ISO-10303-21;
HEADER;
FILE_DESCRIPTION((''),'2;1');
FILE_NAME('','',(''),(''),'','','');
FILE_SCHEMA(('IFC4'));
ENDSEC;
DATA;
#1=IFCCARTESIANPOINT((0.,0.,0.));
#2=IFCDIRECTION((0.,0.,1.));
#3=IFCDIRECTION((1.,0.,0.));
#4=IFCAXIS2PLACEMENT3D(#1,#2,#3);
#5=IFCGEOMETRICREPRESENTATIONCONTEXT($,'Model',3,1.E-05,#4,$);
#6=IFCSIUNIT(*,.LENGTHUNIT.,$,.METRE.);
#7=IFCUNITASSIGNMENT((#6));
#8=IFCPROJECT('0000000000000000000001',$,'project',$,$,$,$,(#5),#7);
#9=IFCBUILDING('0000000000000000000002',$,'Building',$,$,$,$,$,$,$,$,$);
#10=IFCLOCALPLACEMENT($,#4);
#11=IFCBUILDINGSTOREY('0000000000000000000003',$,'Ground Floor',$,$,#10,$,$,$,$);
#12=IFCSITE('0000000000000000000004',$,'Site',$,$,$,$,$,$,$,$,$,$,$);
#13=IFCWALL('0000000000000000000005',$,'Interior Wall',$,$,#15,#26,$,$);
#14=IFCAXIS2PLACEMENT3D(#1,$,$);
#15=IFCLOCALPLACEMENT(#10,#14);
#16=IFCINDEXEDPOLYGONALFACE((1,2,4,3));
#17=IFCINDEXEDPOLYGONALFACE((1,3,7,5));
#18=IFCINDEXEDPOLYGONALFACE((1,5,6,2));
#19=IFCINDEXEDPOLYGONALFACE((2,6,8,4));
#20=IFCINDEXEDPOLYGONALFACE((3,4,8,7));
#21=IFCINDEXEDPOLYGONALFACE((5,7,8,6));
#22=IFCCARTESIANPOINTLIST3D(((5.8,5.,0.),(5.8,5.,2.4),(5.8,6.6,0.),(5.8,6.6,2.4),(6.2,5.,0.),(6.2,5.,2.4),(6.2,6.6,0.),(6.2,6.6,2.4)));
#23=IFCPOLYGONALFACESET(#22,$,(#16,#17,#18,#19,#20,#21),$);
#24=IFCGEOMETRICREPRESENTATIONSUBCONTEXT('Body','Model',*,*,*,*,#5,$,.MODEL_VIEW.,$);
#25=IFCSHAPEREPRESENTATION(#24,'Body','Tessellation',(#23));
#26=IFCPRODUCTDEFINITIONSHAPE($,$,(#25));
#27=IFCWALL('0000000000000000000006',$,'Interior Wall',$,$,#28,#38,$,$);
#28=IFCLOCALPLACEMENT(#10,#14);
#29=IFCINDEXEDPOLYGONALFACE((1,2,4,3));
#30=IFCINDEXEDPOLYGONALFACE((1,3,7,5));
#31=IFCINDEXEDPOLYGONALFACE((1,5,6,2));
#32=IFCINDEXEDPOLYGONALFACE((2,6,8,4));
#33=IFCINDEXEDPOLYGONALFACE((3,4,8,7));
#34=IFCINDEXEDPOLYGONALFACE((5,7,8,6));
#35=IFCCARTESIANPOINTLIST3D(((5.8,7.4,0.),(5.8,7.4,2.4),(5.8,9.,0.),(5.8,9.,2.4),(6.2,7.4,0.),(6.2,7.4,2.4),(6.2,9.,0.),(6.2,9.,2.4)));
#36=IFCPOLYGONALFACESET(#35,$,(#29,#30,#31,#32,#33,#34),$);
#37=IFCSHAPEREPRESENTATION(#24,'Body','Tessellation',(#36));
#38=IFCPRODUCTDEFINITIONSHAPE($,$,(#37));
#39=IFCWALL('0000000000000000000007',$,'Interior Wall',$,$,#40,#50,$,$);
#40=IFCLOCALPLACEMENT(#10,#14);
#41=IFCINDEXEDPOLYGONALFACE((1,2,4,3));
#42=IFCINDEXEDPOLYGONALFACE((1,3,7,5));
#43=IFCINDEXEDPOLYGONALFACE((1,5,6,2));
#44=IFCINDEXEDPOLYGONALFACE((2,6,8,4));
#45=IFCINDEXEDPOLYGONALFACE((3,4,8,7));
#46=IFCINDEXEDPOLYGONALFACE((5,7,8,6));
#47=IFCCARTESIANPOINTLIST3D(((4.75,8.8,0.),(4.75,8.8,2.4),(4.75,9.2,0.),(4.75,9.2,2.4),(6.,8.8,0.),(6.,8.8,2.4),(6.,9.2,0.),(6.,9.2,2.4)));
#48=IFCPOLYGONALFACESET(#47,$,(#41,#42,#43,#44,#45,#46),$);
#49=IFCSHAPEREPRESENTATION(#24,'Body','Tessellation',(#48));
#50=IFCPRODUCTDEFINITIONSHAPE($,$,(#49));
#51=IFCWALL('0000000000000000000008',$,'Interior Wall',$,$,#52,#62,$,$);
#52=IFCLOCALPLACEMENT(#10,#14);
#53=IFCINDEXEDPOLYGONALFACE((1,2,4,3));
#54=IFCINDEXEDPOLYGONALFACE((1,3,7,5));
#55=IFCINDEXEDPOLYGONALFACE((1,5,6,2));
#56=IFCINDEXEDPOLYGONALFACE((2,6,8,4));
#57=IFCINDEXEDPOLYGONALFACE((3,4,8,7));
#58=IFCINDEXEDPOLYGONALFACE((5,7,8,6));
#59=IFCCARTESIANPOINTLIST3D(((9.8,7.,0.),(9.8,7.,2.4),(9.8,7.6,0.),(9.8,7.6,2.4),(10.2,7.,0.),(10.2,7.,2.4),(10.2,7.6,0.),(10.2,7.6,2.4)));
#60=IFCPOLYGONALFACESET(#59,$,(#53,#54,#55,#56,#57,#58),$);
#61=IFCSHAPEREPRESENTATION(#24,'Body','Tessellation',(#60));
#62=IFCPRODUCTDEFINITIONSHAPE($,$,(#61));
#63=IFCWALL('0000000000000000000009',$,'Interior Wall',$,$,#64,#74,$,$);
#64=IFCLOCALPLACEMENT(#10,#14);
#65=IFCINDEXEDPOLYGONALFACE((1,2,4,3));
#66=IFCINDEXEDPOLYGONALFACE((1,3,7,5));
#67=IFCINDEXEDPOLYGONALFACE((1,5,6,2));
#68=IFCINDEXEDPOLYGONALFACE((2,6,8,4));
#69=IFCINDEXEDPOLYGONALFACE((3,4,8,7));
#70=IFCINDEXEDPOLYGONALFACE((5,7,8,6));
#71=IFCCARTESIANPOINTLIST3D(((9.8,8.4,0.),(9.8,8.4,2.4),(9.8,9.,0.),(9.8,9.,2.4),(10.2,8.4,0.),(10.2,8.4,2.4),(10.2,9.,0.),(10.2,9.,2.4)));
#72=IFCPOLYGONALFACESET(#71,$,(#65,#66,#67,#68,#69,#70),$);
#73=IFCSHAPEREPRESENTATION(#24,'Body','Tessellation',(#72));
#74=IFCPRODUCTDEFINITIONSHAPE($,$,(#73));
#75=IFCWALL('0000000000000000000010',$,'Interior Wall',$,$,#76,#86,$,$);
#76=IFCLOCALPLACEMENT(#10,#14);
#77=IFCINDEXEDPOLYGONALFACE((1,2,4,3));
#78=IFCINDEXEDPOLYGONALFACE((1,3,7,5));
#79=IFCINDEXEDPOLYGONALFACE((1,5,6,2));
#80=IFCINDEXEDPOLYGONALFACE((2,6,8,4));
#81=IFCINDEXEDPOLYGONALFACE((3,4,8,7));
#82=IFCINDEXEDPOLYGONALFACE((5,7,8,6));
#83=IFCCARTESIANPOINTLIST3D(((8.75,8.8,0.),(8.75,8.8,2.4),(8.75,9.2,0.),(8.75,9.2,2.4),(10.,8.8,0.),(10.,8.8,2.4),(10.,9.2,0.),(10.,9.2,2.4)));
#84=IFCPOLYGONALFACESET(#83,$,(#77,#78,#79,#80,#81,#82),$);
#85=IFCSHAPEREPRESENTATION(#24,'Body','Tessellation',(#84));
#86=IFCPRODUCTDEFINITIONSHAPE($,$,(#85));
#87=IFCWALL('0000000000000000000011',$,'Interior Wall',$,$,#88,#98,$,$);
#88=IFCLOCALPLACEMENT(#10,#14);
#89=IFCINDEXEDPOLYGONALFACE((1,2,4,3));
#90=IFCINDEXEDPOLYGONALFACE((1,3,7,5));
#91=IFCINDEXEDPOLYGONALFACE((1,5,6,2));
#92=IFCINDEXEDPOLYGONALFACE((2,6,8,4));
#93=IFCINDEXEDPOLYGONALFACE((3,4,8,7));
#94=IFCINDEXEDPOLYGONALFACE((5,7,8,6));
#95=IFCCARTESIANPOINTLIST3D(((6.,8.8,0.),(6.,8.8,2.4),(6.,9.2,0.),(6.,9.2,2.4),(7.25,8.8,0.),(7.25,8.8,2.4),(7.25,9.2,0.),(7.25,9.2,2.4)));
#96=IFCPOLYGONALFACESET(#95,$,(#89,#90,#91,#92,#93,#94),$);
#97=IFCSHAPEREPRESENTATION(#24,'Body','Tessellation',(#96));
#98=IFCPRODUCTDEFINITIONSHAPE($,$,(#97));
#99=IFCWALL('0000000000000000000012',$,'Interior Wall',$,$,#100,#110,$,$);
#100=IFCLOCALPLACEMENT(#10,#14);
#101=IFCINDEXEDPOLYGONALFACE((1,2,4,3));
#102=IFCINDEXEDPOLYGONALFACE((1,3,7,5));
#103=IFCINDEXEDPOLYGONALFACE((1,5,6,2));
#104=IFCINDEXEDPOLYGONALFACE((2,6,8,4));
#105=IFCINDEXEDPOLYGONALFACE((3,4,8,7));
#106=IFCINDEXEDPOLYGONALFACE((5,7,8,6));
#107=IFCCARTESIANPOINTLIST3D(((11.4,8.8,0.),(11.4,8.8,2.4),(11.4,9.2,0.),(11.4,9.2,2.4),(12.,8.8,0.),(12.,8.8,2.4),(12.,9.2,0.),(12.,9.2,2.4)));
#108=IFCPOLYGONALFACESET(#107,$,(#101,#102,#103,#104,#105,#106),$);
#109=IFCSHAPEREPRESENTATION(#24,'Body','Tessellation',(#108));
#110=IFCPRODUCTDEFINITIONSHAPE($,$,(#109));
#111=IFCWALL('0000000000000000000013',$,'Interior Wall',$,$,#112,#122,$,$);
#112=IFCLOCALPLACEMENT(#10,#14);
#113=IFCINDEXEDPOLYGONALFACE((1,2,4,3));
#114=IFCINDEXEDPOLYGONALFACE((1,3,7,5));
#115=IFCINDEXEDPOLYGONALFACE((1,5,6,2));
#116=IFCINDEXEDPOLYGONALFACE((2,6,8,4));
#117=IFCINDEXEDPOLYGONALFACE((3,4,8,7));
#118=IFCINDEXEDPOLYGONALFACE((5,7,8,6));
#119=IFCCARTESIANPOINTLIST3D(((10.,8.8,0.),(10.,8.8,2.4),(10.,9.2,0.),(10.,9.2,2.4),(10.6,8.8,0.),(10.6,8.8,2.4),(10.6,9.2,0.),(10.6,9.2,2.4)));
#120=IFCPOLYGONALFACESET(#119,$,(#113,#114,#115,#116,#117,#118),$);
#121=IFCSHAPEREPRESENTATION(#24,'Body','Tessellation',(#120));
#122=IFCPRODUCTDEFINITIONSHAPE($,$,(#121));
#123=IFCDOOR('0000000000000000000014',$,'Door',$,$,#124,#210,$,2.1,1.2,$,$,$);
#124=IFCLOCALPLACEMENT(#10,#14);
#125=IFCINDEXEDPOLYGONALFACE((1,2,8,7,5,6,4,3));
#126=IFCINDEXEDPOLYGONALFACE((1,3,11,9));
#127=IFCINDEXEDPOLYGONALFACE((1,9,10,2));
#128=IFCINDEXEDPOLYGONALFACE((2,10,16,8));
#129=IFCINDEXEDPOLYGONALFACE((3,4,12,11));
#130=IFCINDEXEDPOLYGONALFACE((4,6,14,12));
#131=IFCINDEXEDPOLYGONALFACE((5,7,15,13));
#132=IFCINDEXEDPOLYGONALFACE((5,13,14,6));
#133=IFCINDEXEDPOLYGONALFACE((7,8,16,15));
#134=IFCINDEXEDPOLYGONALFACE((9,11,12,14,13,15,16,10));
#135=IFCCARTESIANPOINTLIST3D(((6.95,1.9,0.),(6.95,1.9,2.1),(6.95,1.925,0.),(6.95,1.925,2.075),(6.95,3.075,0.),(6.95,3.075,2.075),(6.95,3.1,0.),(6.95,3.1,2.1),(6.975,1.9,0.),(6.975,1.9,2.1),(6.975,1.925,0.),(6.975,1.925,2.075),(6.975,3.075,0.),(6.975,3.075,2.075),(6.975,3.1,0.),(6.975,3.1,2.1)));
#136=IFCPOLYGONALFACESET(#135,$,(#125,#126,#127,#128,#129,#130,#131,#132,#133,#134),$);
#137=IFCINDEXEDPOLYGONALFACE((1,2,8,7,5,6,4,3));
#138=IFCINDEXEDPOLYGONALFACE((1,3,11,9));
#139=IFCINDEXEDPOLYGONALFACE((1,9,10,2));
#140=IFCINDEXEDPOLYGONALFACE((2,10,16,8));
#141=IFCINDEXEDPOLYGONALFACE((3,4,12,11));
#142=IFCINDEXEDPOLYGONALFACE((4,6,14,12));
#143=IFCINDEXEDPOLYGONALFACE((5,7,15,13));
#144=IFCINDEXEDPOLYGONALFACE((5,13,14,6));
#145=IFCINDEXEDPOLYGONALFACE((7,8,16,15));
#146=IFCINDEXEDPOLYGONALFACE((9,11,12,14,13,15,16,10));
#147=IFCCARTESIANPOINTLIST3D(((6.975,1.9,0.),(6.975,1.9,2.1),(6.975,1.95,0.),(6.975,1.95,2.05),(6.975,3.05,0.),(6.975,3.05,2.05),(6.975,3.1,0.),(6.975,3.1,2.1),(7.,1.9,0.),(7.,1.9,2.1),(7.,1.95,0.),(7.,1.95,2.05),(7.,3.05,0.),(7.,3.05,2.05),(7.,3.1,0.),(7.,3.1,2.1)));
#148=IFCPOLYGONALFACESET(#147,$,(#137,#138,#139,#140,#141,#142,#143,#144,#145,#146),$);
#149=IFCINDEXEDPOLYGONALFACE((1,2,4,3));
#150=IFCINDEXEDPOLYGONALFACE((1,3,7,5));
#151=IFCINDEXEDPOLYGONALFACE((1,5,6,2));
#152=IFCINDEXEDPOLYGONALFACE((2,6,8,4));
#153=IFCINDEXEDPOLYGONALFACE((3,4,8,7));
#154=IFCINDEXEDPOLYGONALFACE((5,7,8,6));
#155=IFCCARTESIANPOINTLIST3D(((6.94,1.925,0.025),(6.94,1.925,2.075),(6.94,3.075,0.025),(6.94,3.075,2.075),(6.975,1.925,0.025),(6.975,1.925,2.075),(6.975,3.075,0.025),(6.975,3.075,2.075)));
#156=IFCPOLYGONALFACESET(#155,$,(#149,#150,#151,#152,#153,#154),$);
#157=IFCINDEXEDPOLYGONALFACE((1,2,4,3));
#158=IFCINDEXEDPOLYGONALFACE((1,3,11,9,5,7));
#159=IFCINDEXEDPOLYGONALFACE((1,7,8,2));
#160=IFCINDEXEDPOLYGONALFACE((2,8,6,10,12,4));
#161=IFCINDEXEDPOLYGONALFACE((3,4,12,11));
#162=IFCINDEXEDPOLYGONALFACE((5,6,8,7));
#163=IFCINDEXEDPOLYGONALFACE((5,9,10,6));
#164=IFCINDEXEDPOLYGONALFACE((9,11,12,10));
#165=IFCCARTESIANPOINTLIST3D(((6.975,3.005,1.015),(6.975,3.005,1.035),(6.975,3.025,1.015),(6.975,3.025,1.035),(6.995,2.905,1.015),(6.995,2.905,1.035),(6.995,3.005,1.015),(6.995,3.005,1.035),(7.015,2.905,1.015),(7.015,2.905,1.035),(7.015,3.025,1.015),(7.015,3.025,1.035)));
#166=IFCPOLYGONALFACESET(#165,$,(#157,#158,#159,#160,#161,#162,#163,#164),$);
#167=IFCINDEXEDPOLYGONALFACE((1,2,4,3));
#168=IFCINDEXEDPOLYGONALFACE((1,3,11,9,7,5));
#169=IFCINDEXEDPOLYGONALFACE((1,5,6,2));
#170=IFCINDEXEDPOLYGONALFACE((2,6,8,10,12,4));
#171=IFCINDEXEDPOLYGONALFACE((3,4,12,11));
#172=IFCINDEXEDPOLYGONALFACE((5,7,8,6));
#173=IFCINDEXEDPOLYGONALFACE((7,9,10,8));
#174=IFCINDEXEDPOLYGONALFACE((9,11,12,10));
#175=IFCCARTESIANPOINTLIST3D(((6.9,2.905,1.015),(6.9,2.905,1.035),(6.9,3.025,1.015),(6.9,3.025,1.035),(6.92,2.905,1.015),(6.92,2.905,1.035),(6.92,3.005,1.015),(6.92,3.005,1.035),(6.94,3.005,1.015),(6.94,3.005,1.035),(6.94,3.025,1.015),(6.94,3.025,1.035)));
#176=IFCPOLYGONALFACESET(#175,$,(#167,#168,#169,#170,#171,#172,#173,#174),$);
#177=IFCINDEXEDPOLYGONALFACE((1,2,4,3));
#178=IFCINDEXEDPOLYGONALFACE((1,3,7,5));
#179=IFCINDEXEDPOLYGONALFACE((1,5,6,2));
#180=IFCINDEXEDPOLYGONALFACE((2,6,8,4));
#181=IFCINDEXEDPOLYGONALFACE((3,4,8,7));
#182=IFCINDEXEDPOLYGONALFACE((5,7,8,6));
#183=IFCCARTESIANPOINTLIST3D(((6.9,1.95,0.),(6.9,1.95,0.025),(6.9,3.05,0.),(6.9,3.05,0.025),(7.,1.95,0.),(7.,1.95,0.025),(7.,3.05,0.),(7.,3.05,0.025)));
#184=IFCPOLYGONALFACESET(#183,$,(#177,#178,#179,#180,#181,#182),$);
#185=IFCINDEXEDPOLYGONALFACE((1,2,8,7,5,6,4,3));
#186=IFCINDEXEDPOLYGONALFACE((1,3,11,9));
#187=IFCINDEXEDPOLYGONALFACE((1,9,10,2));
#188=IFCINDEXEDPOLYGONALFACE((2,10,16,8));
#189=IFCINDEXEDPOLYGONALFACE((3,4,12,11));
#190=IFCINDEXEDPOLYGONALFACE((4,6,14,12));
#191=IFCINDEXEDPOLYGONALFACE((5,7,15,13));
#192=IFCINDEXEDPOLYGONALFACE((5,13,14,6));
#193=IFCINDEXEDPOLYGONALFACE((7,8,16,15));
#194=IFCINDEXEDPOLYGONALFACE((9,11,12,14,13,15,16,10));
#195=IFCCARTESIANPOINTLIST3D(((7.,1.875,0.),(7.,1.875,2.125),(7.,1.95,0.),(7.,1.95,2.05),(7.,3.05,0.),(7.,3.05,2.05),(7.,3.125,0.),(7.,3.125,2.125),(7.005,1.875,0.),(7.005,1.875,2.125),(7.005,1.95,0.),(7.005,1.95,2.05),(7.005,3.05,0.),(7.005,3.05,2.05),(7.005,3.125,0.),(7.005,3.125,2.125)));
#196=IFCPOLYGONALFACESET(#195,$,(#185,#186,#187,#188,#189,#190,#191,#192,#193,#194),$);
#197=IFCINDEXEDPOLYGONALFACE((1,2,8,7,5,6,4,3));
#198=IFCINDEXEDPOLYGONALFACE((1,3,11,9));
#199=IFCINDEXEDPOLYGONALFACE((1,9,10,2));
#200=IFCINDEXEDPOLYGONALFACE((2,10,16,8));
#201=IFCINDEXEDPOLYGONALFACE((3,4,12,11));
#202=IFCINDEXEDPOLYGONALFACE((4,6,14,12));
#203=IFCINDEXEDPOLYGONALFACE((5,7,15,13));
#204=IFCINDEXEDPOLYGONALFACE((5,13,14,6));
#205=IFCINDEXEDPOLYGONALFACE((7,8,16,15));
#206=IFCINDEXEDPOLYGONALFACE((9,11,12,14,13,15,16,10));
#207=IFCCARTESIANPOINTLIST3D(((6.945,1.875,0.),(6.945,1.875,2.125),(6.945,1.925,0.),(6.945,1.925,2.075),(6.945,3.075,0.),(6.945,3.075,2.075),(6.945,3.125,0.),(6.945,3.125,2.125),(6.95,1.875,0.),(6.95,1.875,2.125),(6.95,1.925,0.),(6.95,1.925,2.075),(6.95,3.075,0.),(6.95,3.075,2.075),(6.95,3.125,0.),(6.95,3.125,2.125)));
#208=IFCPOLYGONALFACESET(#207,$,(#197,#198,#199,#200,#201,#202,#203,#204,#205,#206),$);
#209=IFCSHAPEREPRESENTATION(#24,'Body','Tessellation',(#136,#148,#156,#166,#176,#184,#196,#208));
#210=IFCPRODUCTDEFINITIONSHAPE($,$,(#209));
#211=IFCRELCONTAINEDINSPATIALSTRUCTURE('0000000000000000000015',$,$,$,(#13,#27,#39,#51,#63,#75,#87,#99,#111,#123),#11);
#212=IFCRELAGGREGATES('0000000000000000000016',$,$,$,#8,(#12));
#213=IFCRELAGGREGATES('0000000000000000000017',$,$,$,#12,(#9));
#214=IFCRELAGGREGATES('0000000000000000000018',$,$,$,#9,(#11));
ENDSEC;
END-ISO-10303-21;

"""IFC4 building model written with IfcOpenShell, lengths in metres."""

from ifc_helpers import new_model, si_unit, frame, origin_with_axes, place, context, subcontext, project, spatial, line, indexed_curve, outline, extrude, element, save


model = new_model("IFC4")

# Units and contexts
model_context = context("Model", 3, precision=1e-05, world=origin_with_axes())
body_context = subcontext(model_context, "Body", "Model", "MODEL_VIEW")
ifc_project = project(units=[si_unit("LENGTHUNIT", "METRE")], contexts=[model_context])

# Site, building, storey
site = spatial("IfcSite", under=ifc_project, Name="Site")
building = spatial("IfcBuilding", under=site, Name="Building")
storey_placement = place(None, origin_with_axes())
storey = spatial("IfcBuildingStorey", under=building, at=storey_placement, Name="Ground Floor")

# Walls
for number, where, z_axis, x_axis, name in (
    (1, (6.0, 5.0, 0.0), (0.0, 0.0, 1.0), (0.0, 1.0, 0.0), "Interior Wall"),
    (2, (6.0, 7.4, 0.0), (0.0, 0.0, 1.0), (0.0, 1.0, 0.0), "Interior Wall"),
):
    element("IfcWall", number, at=place(storey_placement, frame(where, z_axis=z_axis, x_axis=x_axis)), inside=storey, Name=name, context=body_context, shape_type="SweptSolid", body=[
        extrude(outline(indexed_curve([(0.0, 0.0), (0.0, 0.4), (1.6, 0.4), (1.6, 0.0), (0.0, 0.0)], self_intersect=False)), frame((0.0, -0.2, 0.0), z_axis=(0.0, 0.0, 1.0), x_axis=(1.0, 0.0, 0.0)), (0.0, 0.0, 1.0), 2.4),
    ])
wall_1_placement = place(storey_placement, frame((6.0, 9.0, 0.0), z_axis=(0.0, 0.0, 1.0), x_axis=(-1.0, 0.0, 0.0)))
element("IfcWall", 3, at=wall_1_placement, inside=storey, Name="Interior Wall", context=body_context, shape_type="SweptSolid", body=[
    extrude(outline(indexed_curve([(0.0, 0.0), (0.0, 0.4), (1.25, 0.4), (1.25, 0.0), (0.0, 0.0)], self_intersect=False)), frame((0.0, -0.2, 0.0), z_axis=(0.0, 0.0, 1.0), x_axis=(1.0, 0.0, 0.0)), (0.0, 0.0, 1.0), 2.4),
])
for number, where, z_axis, x_axis, name in (
    (4, (10.0, 7.0, 0.0), (0.0, 0.0, 1.0), (0.0, 1.0, 0.0), "Interior Wall"),
    (5, (10.0, 8.4, 0.0), (0.0, 0.0, 1.0), (0.0, 1.0, 0.0), "Interior Wall"),
):
    element("IfcWall", number, at=place(storey_placement, frame(where, z_axis=z_axis, x_axis=x_axis)), inside=storey, Name=name, context=body_context, shape_type="SweptSolid", body=[
        extrude(outline(indexed_curve([(0.0, 0.0), (0.0, 0.4), (0.6, 0.4), (0.6, 0.0), (0.0, 0.0)], self_intersect=False)), frame((0.0, -0.2, 0.0), z_axis=(0.0, 0.0, 1.0), x_axis=(1.0, 0.0, 0.0)), (0.0, 0.0, 1.0), 2.4),
    ])
for number, where, z_axis, x_axis, name in (
    (6, (10.0, 9.0, 0.0), (0.0, 0.0, 1.0), (-1.0, 0.0, 0.0), "Interior Wall"),
    (7, (7.25, 9.0, 0.0), (0.0, 0.0, 1.0), (-1.0, 0.0, 0.0), "Interior Wall"),
):
    element("IfcWall", number, at=place(storey_placement, frame(where, z_axis=z_axis, x_axis=x_axis)), inside=storey, Name=name, context=body_context, shape_type="SweptSolid", body=[
        extrude(outline(indexed_curve([(0.0, 0.0), (0.0, 0.4), (1.25, 0.4), (1.25, 0.0), (0.0, 0.0)], self_intersect=False)), frame((0.0, -0.2, 0.0), z_axis=(0.0, 0.0, 1.0), x_axis=(1.0, 0.0, 0.0)), (0.0, 0.0, 1.0), 2.4),
    ])
for number, where, z_axis, x_axis, name in (
    (8, (12.0, 9.0, 0.0), (0.0, 0.0, 1.0), (-1.0, 0.0, 0.0), "Interior Wall"),
    (9, (10.6, 9.0, 0.0), (0.0, 0.0, 1.0), (-1.0, 0.0, 0.0), "Interior Wall"),
):
    element("IfcWall", number, at=place(storey_placement, frame(where, z_axis=z_axis, x_axis=x_axis)), inside=storey, Name=name, context=body_context, shape_type="SweptSolid", body=[
        extrude(outline(indexed_curve([(0.0, 0.0), (0.0, 0.4), (0.6, 0.4), (0.6, 0.0), (0.0, 0.0)], self_intersect=False)), frame((0.0, -0.2, 0.0), z_axis=(0.0, 0.0, 1.0), x_axis=(1.0, 0.0, 0.0)), (0.0, 0.0, 1.0), 2.4),
    ])

# Door
door_1_placement = place(storey_placement, frame((7.0, 1.9, 0.0), z_axis=(0.0, 0.0, 1.0), x_axis=(0.0, 1.0, 0.0)))
element("IfcDoor", 10, at=door_1_placement, inside=storey, Name="Door", OverallHeight=2.1, OverallWidth=1.2, context=body_context, shape_type="SweptSolid", body=[
    extrude(outline(indexed_curve([(0.0, 0.0), (0.0, 2.1), (1.2, 2.1), (1.2, 0.0), (1.175, 0.0), (1.175, 2.075), (0.025, 2.075), (0.025, 0.0)], segments=[line(1, 2, 3, 4, 5, 6, 7, 8, 1)])), frame((0.0, 0.025, 0.0), z_axis=(0.0, -1.0, 0.0), x_axis=(1.0, 0.0, 0.0)), (0.0, 0.0, -1.0), 0.025),
    extrude(outline(indexed_curve([(0.0, 0.0), (0.0, 2.1), (1.2, 2.1), (1.2, 0.0), (1.15, 0.0), (1.15, 2.05), (0.05, 2.05), (0.05, 0.0)], segments=[line(1, 2, 3, 4, 5, 6, 7, 8, 1)])), frame((0.0, 0.0, 0.0), z_axis=(0.0, -1.0, 0.0), x_axis=(1.0, 0.0, 0.0)), (0.0, 0.0, -1.0), 0.025),
    extrude(outline(indexed_curve([(0.0, 0.0), (1.15, 0.0), (1.15, 0.035), (0.0, 0.035)], segments=[line(1, 2, 3, 4, 1)])), frame((0.025, 0.025, 0.025), z_axis=(0.0, 0.0, 1.0), x_axis=(1.0, 0.0, 0.0)), (0.0, 0.0, 1.0), 2.05),
    extrude(outline(indexed_curve([(0.0, 0.0), (0.0, -0.04), (-0.12, -0.04), (-0.12, -0.02), (-0.02, -0.02), (-0.02, 0.0)], segments=[line(1, 2, 3, 4, 5, 6, 1)])), frame((1.125, 0.025, 1.015), z_axis=(0.0, 0.0, 1.0), x_axis=(1.0, 0.0, 0.0)), (0.0, 0.0, 1.0), 0.02),
    extrude(outline(indexed_curve([(0.0, 0.0), (0.0, 0.04), (-0.12, 0.04), (-0.12, 0.02), (-0.02, 0.02), (-0.02, 0.0)], segments=[line(1, 2, 3, 4, 5, 6, 1)])), frame((1.125, 0.06, 1.015), z_axis=(0.0, 0.0, 1.0), x_axis=(1.0, 0.0, 0.0)), (0.0, 0.0, 1.0), 0.02),
    extrude(outline(indexed_curve([(0.0, 0.0), (1.1, 0.0), (1.1, 0.1), (0.0, 0.1)], segments=[line(1, 2, 3, 4, 1)])), frame((0.05, 0.0, 0.0), z_axis=(0.0, 0.0, 1.0), x_axis=(1.0, 0.0, 0.0)), (0.0, 0.0, 1.0), 0.025),
    extrude(outline(indexed_curve([(0.0, 0.0), (0.0, 2.125), (1.25, 2.125), (1.25, 0.0), (1.175, 0.0), (1.175, 2.05), (0.075, 2.05), (0.075, 0.0)], segments=[line(1, 2, 3, 4, 5, 6, 7, 8, 1)])), frame((-0.025, -0.005, 0.0), z_axis=(0.0, -1.0, 0.0), x_axis=(1.0, 0.0, 0.0)), (0.0, 0.0, -1.0), 0.005),
    extrude(outline(indexed_curve([(0.0, 0.0), (0.0, 2.125), (1.25, 2.125), (1.25, 0.0), (1.2, 0.0), (1.2, 2.075), (0.05, 2.075), (0.05, 0.0)], segments=[line(1, 2, 3, 4, 5, 6, 7, 8, 1)])), frame((-0.025, 0.05, 0.0), z_axis=(0.0, -1.0, 0.0), x_axis=(1.0, 0.0, 0.0)), (0.0, 0.0, -1.0), 0.005),
])

save(model, "model.ifc")
